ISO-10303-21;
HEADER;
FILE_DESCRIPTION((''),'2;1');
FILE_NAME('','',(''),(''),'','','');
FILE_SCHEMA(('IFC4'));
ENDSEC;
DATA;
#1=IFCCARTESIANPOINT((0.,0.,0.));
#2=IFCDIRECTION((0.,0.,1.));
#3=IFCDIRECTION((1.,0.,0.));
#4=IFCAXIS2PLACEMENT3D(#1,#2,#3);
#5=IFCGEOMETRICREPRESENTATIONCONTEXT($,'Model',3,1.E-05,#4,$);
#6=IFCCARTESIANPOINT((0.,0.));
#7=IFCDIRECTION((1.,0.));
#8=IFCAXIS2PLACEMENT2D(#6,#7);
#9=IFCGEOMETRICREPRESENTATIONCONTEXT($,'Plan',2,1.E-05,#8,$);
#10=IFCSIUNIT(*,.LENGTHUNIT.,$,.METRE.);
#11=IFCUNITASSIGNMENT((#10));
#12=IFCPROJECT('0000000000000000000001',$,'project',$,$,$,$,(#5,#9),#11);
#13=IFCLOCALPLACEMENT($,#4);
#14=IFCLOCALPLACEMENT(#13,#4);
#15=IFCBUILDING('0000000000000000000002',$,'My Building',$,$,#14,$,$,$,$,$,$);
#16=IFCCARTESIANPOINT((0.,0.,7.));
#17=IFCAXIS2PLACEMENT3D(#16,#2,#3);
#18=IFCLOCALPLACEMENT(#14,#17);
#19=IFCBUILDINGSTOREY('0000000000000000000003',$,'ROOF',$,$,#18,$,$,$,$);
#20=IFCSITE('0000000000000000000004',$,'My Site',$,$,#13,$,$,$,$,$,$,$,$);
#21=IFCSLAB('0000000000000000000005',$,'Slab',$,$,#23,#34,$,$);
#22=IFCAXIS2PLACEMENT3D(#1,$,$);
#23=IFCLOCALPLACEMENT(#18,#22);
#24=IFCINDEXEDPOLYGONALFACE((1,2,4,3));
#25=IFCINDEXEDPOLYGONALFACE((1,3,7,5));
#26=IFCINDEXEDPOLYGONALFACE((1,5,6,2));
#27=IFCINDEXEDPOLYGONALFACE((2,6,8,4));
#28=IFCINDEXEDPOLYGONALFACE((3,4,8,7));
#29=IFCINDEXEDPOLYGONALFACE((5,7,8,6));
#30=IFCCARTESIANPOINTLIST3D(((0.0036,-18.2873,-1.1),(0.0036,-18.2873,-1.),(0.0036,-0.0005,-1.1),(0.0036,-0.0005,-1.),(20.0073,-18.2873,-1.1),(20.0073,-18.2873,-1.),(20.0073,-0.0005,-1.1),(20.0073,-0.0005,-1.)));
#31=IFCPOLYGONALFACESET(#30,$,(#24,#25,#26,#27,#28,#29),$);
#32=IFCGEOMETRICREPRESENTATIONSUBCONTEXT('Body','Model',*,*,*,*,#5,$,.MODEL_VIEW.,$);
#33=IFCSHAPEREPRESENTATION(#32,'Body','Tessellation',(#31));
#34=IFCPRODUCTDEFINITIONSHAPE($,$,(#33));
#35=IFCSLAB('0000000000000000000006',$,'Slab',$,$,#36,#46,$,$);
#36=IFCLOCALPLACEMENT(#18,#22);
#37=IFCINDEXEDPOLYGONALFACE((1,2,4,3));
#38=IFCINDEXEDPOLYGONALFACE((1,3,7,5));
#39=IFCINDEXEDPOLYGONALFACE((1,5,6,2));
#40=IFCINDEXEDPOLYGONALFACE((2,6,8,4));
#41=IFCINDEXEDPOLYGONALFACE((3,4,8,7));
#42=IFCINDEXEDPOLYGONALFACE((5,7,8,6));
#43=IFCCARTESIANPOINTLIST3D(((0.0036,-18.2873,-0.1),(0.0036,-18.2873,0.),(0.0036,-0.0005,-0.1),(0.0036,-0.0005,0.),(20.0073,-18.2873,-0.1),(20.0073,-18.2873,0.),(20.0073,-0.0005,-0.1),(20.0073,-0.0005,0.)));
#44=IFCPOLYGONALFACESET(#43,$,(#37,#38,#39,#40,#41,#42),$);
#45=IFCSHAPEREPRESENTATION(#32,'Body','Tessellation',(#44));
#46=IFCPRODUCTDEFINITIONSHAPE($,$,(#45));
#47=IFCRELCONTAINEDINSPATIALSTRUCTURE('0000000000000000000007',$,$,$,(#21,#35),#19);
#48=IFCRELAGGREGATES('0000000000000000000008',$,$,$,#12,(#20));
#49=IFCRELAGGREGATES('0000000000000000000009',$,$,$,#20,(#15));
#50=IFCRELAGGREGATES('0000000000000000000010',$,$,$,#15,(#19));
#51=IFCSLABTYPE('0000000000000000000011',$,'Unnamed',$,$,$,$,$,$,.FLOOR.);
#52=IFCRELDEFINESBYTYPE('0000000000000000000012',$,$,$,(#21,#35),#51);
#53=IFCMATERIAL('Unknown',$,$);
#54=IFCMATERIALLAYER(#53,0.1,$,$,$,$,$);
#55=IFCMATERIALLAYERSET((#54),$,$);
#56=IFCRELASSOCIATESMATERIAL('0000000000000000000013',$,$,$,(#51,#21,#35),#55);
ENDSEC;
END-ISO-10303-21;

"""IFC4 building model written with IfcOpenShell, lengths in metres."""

from ifc_helpers import new_model, si_unit, frame, origin_with_axes, origin_2d_with_axis, place, context, subcontext, project, spatial, indexed_curve, outline, extrude, material, layer, layer_set, layer_usage, type_object, element, save


model = new_model("IFC4")

# Units and contexts
model_context = context("Model", 3, precision=1e-05, world=origin_with_axes())
plan_context = context("Plan", 2, precision=1e-05, world=origin_2d_with_axis())
body_context = subcontext(model_context, "Body", "Model", "MODEL_VIEW")
ifc_project = project(units=[si_unit("LENGTHUNIT", "METRE")], contexts=[model_context, plan_context])

# Site, building, storey
site_placement = place(None, origin_with_axes())
site = spatial("IfcSite", under=ifc_project, at=site_placement, Name="My Site")
building_placement = place(site_placement, origin_with_axes())
building = spatial("IfcBuilding", under=site, at=building_placement, Name="My Building")
storey_placement = place(building_placement, frame((0.0, 0.0, 7.0), z_axis=(0.0, 0.0, 1.0), x_axis=(1.0, 0.0, 0.0)))
storey = spatial("IfcBuildingStorey", under=building, at=storey_placement, Name="ROOF")

# Slabs
ifc_material = material(Name="Unknown")
ifc_layer = layer(ifc_material, 0.1)
ifc_layer_set = layer_set([ifc_layer])
ifc_layer_usage_1 = layer_usage(ifc_layer_set, "AXIS3", "POSITIVE", -0.1)
slab_type = type_object("IfcSlabType", Name="Unnamed", PredefinedType="FLOOR", material=ifc_layer_set)
slab_1_placement = place(storey_placement, frame((0.0036, -0.0005, -1.0), z_axis=(0.0, 0.0, 1.0), x_axis=(1.0, 0.0, 0.0)))
element("IfcSlab", 1, at=slab_1_placement, inside=storey, type_object=slab_type, material=ifc_layer_usage_1, Name="Slab", context=body_context, shape_type="SweptSolid", body=[
    extrude(outline(indexed_curve([(0.0, 0.0), (0.0, -18.2869), (20.0037, -18.2869), (20.0037, 0.0), (0.0, 0.0)])), frame((0.0, 0.0, -0.1), z_axis=(0.0, 0.0, 1.0), x_axis=(1.0, 0.0, 0.0)), (0.0, 0.0, 1.0), 0.1),
])
ifc_layer_usage_2 = layer_usage(ifc_layer_set, "AXIS3", "POSITIVE", -0.1)
slab_2_placement = place(storey_placement, frame((0.0036, -0.0005, 0.0), z_axis=(0.0, 0.0, 1.0), x_axis=(1.0, 0.0, 0.0)))
element("IfcSlab", 2, at=slab_2_placement, inside=storey, type_object=slab_type, material=ifc_layer_usage_2, Name="Slab", context=body_context, shape_type="SweptSolid", body=[
    extrude(outline(indexed_curve([(0.0, 0.0), (20.0037, 0.0), (20.0037, -18.2869), (0.0, -18.2869), (0.0, 0.0)])), frame((0.0, 0.0, -0.1), z_axis=(0.0, 0.0, 1.0), x_axis=(1.0, 0.0, 0.0)), (0.0, 0.0, 1.0), 0.1),
])

save(model, "model.ifc")
